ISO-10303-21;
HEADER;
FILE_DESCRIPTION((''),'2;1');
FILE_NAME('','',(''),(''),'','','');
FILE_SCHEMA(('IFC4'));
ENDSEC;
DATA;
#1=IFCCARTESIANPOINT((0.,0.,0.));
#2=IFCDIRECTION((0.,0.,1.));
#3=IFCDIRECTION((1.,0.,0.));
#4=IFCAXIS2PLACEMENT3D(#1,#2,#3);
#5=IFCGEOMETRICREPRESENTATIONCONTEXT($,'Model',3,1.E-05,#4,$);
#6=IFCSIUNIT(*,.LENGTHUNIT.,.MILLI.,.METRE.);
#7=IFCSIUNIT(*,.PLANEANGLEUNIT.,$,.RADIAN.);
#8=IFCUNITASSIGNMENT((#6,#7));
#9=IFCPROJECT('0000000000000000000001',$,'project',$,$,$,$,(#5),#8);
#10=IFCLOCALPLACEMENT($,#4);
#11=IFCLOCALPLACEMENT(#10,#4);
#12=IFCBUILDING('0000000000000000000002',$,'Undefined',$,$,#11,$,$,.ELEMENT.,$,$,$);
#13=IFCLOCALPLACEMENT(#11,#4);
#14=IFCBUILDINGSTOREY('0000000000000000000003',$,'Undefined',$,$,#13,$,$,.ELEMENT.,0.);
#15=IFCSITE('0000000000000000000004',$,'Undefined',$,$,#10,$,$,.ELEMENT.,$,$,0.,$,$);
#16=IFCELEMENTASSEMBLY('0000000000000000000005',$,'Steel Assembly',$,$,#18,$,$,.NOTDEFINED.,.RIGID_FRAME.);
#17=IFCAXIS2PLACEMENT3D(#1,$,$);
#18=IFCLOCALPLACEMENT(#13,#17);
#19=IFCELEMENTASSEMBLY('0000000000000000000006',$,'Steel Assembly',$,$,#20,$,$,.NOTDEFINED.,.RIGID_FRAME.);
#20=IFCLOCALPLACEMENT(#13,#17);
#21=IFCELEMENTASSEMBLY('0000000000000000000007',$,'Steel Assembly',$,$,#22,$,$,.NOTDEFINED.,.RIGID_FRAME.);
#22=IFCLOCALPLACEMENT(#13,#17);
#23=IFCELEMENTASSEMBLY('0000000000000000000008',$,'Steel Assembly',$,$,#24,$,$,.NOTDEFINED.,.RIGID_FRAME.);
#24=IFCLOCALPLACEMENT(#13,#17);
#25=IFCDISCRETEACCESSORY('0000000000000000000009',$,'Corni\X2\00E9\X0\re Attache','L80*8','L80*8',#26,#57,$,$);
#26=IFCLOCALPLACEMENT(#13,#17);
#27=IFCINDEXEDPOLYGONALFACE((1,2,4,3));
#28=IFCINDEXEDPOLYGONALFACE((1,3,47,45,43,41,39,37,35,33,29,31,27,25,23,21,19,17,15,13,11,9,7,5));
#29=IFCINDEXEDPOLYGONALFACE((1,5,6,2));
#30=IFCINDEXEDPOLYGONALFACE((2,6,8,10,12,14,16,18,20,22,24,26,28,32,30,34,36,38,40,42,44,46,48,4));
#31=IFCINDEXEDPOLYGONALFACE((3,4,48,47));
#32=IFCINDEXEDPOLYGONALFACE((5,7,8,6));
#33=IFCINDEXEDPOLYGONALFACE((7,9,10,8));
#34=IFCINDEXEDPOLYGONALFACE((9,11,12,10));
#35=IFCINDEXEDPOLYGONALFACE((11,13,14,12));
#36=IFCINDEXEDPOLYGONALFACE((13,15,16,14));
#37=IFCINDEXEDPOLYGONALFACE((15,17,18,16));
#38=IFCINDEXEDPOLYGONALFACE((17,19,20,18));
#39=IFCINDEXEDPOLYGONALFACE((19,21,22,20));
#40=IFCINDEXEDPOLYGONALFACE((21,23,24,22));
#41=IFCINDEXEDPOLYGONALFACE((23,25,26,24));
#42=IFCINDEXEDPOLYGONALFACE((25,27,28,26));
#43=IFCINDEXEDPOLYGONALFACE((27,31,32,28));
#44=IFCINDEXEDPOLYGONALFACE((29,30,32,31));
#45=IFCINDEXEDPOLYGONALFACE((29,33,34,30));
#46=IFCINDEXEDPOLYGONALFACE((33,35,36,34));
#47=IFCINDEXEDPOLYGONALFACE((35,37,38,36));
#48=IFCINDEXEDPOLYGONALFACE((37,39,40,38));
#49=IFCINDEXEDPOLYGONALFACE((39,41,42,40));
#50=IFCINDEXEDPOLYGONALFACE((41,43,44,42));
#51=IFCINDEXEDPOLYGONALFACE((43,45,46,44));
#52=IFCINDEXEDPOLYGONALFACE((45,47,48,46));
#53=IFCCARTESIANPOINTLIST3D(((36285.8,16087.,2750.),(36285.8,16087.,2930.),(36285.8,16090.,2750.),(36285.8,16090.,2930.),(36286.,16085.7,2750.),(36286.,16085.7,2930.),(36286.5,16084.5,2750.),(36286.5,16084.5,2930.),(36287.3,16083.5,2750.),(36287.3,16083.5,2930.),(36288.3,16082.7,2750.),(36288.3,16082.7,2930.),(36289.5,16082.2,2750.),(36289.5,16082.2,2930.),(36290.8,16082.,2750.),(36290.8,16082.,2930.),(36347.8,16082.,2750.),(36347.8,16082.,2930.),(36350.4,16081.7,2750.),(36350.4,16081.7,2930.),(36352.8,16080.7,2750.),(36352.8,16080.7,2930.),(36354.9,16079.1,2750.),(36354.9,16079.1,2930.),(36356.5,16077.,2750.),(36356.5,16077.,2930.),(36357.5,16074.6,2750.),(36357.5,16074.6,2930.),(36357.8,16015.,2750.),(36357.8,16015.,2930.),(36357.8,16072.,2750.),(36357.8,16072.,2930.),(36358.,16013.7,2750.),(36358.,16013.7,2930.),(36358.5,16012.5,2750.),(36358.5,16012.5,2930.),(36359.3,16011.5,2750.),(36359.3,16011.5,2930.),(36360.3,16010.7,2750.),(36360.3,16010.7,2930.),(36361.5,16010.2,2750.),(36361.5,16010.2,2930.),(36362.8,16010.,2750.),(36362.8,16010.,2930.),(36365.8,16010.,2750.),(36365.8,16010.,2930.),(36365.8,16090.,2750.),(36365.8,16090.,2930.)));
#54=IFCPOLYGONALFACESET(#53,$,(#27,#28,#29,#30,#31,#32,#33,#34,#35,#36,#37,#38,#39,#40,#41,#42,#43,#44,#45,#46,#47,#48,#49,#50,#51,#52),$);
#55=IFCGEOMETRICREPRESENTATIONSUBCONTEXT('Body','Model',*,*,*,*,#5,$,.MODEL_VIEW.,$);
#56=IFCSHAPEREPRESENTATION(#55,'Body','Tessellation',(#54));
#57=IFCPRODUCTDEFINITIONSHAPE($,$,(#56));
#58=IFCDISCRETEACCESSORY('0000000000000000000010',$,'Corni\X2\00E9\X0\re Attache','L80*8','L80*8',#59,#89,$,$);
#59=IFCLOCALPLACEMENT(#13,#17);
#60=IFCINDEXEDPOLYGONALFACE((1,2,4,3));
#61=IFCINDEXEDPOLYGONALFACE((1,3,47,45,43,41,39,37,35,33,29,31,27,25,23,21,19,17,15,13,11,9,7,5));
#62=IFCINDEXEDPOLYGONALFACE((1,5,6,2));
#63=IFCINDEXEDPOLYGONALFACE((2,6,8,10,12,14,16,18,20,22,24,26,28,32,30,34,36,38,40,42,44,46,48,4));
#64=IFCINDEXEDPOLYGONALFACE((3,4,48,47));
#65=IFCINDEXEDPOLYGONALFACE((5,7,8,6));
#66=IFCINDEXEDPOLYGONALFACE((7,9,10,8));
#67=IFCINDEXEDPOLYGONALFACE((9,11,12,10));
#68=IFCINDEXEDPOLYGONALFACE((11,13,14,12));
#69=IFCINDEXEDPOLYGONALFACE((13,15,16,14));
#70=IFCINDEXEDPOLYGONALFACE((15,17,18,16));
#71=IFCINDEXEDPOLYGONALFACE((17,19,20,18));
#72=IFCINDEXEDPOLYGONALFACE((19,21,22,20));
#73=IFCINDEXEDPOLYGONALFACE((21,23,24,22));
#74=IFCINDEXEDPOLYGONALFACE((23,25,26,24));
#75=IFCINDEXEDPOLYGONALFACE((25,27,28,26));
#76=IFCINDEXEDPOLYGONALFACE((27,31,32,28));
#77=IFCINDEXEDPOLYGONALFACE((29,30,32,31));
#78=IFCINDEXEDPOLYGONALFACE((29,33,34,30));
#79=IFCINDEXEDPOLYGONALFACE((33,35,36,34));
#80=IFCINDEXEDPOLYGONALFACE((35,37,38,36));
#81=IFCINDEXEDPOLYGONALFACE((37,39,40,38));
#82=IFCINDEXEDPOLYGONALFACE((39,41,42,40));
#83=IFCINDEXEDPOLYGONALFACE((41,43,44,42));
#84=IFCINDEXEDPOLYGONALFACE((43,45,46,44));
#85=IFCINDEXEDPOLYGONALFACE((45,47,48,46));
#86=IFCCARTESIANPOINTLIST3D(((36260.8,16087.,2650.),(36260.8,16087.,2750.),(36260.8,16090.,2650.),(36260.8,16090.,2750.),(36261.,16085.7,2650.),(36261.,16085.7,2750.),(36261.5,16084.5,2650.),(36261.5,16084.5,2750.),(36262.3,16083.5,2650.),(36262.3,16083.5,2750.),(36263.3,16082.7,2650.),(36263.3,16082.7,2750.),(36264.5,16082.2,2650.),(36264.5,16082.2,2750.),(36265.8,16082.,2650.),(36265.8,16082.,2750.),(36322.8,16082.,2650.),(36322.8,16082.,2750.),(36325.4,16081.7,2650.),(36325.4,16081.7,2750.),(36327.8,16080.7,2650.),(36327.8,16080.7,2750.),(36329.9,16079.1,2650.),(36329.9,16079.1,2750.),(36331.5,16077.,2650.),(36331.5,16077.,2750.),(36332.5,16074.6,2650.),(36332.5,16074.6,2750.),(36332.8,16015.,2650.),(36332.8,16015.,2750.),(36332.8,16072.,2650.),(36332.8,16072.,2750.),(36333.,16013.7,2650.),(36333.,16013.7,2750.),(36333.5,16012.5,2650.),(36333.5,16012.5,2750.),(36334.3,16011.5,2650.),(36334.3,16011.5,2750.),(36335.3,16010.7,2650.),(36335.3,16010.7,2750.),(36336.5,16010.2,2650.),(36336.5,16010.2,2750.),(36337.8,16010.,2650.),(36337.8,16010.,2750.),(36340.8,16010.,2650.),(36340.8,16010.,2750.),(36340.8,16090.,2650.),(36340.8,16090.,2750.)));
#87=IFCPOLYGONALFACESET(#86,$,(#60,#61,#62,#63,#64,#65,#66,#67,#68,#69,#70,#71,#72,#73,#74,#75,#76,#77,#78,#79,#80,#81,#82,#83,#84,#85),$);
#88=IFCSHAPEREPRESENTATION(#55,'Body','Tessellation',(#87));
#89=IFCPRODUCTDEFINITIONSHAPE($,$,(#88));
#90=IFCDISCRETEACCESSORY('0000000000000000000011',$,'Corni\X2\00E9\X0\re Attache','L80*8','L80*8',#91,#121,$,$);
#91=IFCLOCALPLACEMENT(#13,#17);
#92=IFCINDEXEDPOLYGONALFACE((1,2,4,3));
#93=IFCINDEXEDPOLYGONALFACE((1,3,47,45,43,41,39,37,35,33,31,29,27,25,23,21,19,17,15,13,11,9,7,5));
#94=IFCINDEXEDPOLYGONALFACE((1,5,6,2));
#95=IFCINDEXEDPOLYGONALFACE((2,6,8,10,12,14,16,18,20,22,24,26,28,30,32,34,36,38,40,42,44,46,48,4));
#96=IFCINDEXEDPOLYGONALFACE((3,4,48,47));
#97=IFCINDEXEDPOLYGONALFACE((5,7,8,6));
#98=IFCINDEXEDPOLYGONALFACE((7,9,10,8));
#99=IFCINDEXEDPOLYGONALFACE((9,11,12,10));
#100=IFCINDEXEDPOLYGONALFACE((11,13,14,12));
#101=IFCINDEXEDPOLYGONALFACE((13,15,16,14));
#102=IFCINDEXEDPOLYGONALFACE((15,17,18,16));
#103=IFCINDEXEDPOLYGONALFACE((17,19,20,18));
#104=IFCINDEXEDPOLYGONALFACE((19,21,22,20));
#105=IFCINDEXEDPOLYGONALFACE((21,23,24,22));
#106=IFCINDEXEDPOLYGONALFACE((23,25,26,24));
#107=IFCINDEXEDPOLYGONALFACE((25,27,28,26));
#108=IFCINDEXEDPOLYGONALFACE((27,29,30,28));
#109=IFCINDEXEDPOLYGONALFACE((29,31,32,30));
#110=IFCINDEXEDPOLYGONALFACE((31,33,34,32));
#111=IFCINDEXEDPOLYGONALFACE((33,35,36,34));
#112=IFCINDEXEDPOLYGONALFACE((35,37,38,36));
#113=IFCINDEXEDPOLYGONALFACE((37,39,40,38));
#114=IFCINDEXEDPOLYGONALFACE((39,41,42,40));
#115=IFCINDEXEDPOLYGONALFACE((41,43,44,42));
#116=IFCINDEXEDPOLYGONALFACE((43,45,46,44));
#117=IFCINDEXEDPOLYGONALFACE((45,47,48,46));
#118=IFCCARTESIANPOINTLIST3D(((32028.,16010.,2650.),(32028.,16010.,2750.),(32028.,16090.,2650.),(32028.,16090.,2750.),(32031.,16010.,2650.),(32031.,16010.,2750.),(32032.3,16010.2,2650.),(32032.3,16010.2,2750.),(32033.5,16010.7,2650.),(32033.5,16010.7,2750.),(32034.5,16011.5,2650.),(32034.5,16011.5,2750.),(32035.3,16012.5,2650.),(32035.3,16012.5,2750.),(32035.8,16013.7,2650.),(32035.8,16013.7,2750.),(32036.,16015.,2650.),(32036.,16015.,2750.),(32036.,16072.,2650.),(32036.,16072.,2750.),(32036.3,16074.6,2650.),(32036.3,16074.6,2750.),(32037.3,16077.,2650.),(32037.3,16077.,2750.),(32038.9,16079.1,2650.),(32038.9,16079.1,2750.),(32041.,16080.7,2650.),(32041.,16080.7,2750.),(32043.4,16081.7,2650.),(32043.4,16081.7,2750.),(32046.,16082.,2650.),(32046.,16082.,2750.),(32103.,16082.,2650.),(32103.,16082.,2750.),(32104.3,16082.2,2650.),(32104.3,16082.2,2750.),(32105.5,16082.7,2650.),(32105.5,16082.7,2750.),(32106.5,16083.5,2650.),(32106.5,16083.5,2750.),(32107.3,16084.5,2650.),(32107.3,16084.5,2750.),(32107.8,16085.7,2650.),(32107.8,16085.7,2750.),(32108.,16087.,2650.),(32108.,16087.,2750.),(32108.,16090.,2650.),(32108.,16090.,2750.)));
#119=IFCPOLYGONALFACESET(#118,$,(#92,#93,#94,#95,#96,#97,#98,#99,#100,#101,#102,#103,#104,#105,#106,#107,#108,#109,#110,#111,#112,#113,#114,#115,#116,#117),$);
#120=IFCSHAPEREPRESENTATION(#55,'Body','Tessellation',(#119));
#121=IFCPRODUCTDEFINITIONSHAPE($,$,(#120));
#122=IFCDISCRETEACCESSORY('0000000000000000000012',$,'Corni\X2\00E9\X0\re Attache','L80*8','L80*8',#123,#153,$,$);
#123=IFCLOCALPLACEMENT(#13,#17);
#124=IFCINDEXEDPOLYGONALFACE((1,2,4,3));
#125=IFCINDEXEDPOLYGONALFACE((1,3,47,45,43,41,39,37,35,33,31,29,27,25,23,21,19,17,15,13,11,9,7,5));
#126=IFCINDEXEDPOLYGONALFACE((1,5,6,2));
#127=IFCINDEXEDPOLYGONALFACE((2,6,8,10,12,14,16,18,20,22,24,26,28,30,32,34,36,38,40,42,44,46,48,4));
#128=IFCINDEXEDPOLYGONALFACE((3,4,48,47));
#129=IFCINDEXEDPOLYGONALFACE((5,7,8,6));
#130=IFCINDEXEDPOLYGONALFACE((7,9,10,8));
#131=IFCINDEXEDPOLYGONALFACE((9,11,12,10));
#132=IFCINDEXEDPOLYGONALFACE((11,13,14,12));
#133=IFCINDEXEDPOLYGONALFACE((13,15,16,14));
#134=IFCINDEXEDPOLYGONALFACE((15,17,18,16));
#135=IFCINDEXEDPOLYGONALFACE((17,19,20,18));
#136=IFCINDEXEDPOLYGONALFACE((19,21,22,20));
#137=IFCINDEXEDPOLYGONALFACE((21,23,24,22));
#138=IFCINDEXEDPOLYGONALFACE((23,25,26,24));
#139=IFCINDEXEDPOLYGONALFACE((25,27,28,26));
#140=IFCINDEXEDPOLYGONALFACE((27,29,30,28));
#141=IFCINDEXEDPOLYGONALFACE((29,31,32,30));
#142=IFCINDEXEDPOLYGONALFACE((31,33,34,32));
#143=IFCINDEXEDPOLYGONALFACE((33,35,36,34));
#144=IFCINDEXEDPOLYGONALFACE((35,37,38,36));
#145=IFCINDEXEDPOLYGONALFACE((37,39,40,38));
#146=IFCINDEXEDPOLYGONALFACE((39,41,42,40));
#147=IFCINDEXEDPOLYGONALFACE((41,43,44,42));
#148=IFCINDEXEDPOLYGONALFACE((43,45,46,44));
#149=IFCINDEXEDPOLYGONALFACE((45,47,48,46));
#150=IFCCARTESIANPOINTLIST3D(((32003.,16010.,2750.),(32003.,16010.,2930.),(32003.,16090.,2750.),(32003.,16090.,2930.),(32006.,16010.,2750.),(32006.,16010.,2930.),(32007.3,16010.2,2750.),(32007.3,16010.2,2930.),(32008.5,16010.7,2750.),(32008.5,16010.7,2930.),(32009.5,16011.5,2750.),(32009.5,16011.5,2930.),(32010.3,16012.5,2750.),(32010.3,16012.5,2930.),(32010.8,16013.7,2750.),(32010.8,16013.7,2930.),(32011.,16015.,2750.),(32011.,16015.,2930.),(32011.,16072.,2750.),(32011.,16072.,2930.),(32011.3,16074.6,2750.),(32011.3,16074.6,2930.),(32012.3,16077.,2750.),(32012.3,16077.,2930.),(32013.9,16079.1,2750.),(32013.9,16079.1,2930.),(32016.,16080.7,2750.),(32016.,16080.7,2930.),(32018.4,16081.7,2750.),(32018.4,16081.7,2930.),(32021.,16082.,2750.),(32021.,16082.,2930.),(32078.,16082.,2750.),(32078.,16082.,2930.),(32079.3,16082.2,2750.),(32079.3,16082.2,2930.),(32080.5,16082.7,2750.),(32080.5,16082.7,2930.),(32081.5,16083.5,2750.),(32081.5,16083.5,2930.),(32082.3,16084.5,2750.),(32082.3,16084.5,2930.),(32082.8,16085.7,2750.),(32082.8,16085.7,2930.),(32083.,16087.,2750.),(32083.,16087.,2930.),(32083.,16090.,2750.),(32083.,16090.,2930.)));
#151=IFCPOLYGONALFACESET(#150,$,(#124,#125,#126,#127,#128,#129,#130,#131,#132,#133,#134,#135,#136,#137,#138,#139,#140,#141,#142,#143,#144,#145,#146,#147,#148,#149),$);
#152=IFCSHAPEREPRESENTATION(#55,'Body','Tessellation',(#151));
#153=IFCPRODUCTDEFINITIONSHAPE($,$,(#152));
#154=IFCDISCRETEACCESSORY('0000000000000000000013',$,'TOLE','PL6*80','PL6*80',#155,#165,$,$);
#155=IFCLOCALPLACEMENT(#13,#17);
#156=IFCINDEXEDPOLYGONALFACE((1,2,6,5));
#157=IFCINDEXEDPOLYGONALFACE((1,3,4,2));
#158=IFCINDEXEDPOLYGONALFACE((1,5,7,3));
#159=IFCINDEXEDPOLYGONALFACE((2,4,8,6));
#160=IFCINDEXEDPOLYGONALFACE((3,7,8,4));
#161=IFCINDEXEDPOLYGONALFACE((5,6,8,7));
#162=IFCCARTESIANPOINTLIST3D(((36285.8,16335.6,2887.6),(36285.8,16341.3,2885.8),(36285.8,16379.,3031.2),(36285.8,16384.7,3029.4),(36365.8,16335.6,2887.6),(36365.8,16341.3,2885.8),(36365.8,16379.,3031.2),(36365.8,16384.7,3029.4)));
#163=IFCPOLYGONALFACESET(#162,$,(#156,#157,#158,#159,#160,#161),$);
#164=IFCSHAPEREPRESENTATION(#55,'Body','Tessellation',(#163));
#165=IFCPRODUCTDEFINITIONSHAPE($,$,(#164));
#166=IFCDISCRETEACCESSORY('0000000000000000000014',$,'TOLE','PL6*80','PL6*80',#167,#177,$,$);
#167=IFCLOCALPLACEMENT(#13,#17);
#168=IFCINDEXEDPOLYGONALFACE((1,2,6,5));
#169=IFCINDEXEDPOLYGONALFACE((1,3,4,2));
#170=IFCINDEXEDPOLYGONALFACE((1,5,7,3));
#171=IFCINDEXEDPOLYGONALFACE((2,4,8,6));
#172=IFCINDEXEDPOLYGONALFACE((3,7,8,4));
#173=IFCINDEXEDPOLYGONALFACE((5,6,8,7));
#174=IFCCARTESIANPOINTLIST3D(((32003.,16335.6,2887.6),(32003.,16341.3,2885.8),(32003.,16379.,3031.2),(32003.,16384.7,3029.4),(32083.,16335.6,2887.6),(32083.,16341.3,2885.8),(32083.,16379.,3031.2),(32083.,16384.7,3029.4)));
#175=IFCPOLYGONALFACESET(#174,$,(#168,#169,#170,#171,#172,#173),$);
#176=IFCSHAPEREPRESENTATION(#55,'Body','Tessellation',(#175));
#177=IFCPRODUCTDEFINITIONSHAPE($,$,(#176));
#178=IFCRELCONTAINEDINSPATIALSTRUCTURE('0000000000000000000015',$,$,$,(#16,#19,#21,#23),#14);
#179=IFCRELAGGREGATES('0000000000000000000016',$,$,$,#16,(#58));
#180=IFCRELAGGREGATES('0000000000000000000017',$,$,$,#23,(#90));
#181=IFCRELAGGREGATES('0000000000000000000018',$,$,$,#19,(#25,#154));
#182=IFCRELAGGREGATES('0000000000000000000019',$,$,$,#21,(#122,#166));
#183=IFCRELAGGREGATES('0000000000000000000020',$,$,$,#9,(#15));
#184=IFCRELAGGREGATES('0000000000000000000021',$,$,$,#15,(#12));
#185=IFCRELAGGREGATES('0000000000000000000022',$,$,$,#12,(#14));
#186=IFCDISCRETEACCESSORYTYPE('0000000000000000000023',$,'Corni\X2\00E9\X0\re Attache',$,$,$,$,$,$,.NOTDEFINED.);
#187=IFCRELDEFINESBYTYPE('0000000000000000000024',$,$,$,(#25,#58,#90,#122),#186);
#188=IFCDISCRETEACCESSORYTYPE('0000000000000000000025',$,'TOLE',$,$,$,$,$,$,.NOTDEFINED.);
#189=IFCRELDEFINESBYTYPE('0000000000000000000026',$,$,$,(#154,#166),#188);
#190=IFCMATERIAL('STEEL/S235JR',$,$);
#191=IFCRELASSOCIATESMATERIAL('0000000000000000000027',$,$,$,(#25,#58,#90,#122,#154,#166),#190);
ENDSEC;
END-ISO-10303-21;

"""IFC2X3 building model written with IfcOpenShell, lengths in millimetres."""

from ifc_helpers import new_model, si_unit, frame, origin_with_axes, origin_2d_with_axis, place, context, subcontext, project, spatial, rectangle, l_section, extrude, material, type_object, element, aggregate, save


model = new_model("IFC2X3")

# Units and contexts
model_context = context("Model", 3, precision=1e-05, world=origin_with_axes())
body_context = subcontext(model_context, "Body", "Model", "MODEL_VIEW")
ifc_project = project(units=[si_unit("LENGTHUNIT", "METRE", prefix="MILLI"), si_unit("PLANEANGLEUNIT", "RADIAN")], contexts=[model_context])

# Site, building, storey
site_placement = place(None, origin_with_axes())
site = spatial("IfcSite", under=ifc_project, at=site_placement, Name="Undefined", CompositionType="ELEMENT", RefElevation=0.0)
building_placement = place(site_placement, origin_with_axes())
building = spatial("IfcBuilding", under=site, at=building_placement, Name="Undefined", CompositionType="ELEMENT")
storey_placement = place(building_placement, origin_with_axes())
storey = spatial("IfcBuildingStorey", under=building, at=storey_placement, Name="Undefined", CompositionType="ELEMENT", Elevation=0.0)

# Element assembly
assembly_1_placement = place(storey_placement, origin_with_axes())
assembly_1 = element("IfcElementAssembly", 1, at=assembly_1_placement, inside=storey, Name="Steel Assembly", AssemblyPlace="NOTDEFINED", PredefinedType="RIGID_FRAME")
ifc_material_1 = material(Name="STEEL/S235JR")

# Element assembly
assembly_2_placement = place(storey_placement, origin_with_axes())
assembly_2 = element("IfcElementAssembly", 2, at=assembly_2_placement, inside=storey, Name="Steel Assembly", AssemblyPlace="NOTDEFINED", PredefinedType="RIGID_FRAME")

# Element assemblies
assembly_3_placement = place(storey_placement, origin_with_axes())
assembly_3 = element("IfcElementAssembly", 3, at=assembly_3_placement, inside=storey, Name="Steel Assembly", AssemblyPlace="NOTDEFINED", PredefinedType="RIGID_FRAME")
assembly_4_placement = place(storey_placement, origin_with_axes())
assembly_4 = element("IfcElementAssembly", 4, at=assembly_4_placement, inside=storey, Name="Steel Assembly", AssemblyPlace="NOTDEFINED", PredefinedType="RIGID_FRAME")

# Discrete accessories
discrete_accessory_type_1 = type_object("IfcDiscreteAccessoryType", Name="Corniére Attache")
discrete_accessory_1_placement = place(assembly_2_placement, frame((36325.8, 16050.0, 2930.0), z_axis=(0.0, -1.0, 0.0), x_axis=(0.0, 0.0, -1.0)))
discrete_accessory_1 = element("IfcDiscreteAccessory", 5, at=discrete_accessory_1_placement, type_object=discrete_accessory_type_1, material=ifc_material_1, Name="Corniére Attache", Description="L80*8", ObjectType="L80*8", context=body_context, shape_type="SweptSolid", body=[
    extrude(l_section(Depth=80.0, Width=80.0, Thickness=8.0, FilletRadius=10.0, EdgeRadius=5.0, at=origin_2d_with_axis()), frame((180.0, 0.0, 0.0), z_axis=(-1.0, 0.0, 0.0), x_axis=(0.0, -1.0, 0.0)), (0.0, 0.0, 1.0), 180.0),
])
discrete_accessory_2_placement = place(assembly_1_placement, frame((36300.8, 16050.0, 2750.0), z_axis=(0.0, -1.0, 0.0), x_axis=(0.0, 0.0, -1.0)))
discrete_accessory_2 = element("IfcDiscreteAccessory", 6, at=discrete_accessory_2_placement, type_object=discrete_accessory_type_1, material=ifc_material_1, Name="Corniére Attache", Description="L80*8", ObjectType="L80*8", context=body_context, shape_type="SweptSolid", body=[
    extrude(l_section(Depth=80.0, Width=80.0, Thickness=8.0, FilletRadius=10.0, EdgeRadius=5.0, at=origin_2d_with_axis()), frame((100.0, 0.0, 0.0), z_axis=(-1.0, 0.0, 0.0), x_axis=(0.0, -1.0, 0.0)), (0.0, 0.0, 1.0), 100.0),
])
aggregate(assembly_1, [discrete_accessory_2])
discrete_accessory_3_placement = place(assembly_4_placement, frame((32068.0, 16050.0, 2650.0), z_axis=(0.0, 0.0, 1.0), x_axis=(1.0, 0.0, 0.0)))
discrete_accessory_3 = element("IfcDiscreteAccessory", 7, at=discrete_accessory_3_placement, type_object=discrete_accessory_type_1, material=ifc_material_1, Name="Corniére Attache", Description="L80*8", ObjectType="L80*8", context=body_context, shape_type="SweptSolid", body=[
    extrude(l_section(Depth=80.0, Width=80.0, Thickness=8.0, FilletRadius=10.0, EdgeRadius=5.0, at=origin_2d_with_axis()), frame((0.0, 0.0, 100.0), z_axis=(0.0, 0.0, -1.0), x_axis=(1.0, 0.0, 0.0)), (0.0, 0.0, 1.0), 100.0),
])
aggregate(assembly_4, [discrete_accessory_3])
discrete_accessory_4_placement = place(assembly_3_placement, frame((32043.0, 16050.0, 2750.0), z_axis=(0.0, 0.0, 1.0), x_axis=(1.0, 0.0, 0.0)))
discrete_accessory_4 = element("IfcDiscreteAccessory", 8, at=discrete_accessory_4_placement, type_object=discrete_accessory_type_1, material=ifc_material_1, Name="Corniére Attache", Description="L80*8", ObjectType="L80*8", context=body_context, shape_type="SweptSolid", body=[
    extrude(l_section(Depth=80.0, Width=80.0, Thickness=8.0, FilletRadius=10.0, EdgeRadius=5.0, at=origin_2d_with_axis()), frame((0.0, 0.0, 180.0), z_axis=(0.0, 0.0, -1.0), x_axis=(1.0, 0.0, 0.0)), (0.0, 0.0, 1.0), 180.0),
])
discrete_accessory_type_2 = type_object("IfcDiscreteAccessoryType", Name="TOLE")
discrete_accessory_5_placement = place(assembly_2_placement, frame((36325.8, 16381.9, 3030.3), z_axis=(1.0, 0.0, 0.0), x_axis=(0.0, -0.289497, -0.957179)))
discrete_accessory_5 = element("IfcDiscreteAccessory", 9, at=discrete_accessory_5_placement, type_object=discrete_accessory_type_2, material=ifc_material_1, Name="TOLE", Description="PL6*80", ObjectType="PL6*80", context=body_context, shape_type="SweptSolid", body=[
    extrude(rectangle(XDim=6.0, YDim=80.0, at=origin_2d_with_axis()), frame((150.0, 0.0, 0.0), z_axis=(-1.0, 0.0, 0.0), x_axis=(0.0, -1.0, 0.0)), (0.0, 0.0, 1.0), 150.0),
])
discrete_accessory_6_placement = place(assembly_3_placement, frame((32043.0, 16381.9, 3030.3), z_axis=(-1.0, 0.0, 0.0), x_axis=(0.0, -0.289497, -0.957179)))
discrete_accessory_6 = element("IfcDiscreteAccessory", 10, at=discrete_accessory_6_placement, type_object=discrete_accessory_type_2, material=ifc_material_1, Name="TOLE", Description="PL6*80", ObjectType="PL6*80", context=body_context, shape_type="SweptSolid", body=[
    extrude(rectangle(XDim=6.0, YDim=80.0, at=origin_2d_with_axis()), frame((150.0, 0.0, 0.0), z_axis=(-1.0, 0.0, 0.0), x_axis=(0.0, -1.0, 0.0)), (0.0, 0.0, 1.0), 150.0),
])
aggregate(assembly_2, [discrete_accessory_1, discrete_accessory_5])
aggregate(assembly_3, [discrete_accessory_4, discrete_accessory_6])

save(model, "model.ifc")
